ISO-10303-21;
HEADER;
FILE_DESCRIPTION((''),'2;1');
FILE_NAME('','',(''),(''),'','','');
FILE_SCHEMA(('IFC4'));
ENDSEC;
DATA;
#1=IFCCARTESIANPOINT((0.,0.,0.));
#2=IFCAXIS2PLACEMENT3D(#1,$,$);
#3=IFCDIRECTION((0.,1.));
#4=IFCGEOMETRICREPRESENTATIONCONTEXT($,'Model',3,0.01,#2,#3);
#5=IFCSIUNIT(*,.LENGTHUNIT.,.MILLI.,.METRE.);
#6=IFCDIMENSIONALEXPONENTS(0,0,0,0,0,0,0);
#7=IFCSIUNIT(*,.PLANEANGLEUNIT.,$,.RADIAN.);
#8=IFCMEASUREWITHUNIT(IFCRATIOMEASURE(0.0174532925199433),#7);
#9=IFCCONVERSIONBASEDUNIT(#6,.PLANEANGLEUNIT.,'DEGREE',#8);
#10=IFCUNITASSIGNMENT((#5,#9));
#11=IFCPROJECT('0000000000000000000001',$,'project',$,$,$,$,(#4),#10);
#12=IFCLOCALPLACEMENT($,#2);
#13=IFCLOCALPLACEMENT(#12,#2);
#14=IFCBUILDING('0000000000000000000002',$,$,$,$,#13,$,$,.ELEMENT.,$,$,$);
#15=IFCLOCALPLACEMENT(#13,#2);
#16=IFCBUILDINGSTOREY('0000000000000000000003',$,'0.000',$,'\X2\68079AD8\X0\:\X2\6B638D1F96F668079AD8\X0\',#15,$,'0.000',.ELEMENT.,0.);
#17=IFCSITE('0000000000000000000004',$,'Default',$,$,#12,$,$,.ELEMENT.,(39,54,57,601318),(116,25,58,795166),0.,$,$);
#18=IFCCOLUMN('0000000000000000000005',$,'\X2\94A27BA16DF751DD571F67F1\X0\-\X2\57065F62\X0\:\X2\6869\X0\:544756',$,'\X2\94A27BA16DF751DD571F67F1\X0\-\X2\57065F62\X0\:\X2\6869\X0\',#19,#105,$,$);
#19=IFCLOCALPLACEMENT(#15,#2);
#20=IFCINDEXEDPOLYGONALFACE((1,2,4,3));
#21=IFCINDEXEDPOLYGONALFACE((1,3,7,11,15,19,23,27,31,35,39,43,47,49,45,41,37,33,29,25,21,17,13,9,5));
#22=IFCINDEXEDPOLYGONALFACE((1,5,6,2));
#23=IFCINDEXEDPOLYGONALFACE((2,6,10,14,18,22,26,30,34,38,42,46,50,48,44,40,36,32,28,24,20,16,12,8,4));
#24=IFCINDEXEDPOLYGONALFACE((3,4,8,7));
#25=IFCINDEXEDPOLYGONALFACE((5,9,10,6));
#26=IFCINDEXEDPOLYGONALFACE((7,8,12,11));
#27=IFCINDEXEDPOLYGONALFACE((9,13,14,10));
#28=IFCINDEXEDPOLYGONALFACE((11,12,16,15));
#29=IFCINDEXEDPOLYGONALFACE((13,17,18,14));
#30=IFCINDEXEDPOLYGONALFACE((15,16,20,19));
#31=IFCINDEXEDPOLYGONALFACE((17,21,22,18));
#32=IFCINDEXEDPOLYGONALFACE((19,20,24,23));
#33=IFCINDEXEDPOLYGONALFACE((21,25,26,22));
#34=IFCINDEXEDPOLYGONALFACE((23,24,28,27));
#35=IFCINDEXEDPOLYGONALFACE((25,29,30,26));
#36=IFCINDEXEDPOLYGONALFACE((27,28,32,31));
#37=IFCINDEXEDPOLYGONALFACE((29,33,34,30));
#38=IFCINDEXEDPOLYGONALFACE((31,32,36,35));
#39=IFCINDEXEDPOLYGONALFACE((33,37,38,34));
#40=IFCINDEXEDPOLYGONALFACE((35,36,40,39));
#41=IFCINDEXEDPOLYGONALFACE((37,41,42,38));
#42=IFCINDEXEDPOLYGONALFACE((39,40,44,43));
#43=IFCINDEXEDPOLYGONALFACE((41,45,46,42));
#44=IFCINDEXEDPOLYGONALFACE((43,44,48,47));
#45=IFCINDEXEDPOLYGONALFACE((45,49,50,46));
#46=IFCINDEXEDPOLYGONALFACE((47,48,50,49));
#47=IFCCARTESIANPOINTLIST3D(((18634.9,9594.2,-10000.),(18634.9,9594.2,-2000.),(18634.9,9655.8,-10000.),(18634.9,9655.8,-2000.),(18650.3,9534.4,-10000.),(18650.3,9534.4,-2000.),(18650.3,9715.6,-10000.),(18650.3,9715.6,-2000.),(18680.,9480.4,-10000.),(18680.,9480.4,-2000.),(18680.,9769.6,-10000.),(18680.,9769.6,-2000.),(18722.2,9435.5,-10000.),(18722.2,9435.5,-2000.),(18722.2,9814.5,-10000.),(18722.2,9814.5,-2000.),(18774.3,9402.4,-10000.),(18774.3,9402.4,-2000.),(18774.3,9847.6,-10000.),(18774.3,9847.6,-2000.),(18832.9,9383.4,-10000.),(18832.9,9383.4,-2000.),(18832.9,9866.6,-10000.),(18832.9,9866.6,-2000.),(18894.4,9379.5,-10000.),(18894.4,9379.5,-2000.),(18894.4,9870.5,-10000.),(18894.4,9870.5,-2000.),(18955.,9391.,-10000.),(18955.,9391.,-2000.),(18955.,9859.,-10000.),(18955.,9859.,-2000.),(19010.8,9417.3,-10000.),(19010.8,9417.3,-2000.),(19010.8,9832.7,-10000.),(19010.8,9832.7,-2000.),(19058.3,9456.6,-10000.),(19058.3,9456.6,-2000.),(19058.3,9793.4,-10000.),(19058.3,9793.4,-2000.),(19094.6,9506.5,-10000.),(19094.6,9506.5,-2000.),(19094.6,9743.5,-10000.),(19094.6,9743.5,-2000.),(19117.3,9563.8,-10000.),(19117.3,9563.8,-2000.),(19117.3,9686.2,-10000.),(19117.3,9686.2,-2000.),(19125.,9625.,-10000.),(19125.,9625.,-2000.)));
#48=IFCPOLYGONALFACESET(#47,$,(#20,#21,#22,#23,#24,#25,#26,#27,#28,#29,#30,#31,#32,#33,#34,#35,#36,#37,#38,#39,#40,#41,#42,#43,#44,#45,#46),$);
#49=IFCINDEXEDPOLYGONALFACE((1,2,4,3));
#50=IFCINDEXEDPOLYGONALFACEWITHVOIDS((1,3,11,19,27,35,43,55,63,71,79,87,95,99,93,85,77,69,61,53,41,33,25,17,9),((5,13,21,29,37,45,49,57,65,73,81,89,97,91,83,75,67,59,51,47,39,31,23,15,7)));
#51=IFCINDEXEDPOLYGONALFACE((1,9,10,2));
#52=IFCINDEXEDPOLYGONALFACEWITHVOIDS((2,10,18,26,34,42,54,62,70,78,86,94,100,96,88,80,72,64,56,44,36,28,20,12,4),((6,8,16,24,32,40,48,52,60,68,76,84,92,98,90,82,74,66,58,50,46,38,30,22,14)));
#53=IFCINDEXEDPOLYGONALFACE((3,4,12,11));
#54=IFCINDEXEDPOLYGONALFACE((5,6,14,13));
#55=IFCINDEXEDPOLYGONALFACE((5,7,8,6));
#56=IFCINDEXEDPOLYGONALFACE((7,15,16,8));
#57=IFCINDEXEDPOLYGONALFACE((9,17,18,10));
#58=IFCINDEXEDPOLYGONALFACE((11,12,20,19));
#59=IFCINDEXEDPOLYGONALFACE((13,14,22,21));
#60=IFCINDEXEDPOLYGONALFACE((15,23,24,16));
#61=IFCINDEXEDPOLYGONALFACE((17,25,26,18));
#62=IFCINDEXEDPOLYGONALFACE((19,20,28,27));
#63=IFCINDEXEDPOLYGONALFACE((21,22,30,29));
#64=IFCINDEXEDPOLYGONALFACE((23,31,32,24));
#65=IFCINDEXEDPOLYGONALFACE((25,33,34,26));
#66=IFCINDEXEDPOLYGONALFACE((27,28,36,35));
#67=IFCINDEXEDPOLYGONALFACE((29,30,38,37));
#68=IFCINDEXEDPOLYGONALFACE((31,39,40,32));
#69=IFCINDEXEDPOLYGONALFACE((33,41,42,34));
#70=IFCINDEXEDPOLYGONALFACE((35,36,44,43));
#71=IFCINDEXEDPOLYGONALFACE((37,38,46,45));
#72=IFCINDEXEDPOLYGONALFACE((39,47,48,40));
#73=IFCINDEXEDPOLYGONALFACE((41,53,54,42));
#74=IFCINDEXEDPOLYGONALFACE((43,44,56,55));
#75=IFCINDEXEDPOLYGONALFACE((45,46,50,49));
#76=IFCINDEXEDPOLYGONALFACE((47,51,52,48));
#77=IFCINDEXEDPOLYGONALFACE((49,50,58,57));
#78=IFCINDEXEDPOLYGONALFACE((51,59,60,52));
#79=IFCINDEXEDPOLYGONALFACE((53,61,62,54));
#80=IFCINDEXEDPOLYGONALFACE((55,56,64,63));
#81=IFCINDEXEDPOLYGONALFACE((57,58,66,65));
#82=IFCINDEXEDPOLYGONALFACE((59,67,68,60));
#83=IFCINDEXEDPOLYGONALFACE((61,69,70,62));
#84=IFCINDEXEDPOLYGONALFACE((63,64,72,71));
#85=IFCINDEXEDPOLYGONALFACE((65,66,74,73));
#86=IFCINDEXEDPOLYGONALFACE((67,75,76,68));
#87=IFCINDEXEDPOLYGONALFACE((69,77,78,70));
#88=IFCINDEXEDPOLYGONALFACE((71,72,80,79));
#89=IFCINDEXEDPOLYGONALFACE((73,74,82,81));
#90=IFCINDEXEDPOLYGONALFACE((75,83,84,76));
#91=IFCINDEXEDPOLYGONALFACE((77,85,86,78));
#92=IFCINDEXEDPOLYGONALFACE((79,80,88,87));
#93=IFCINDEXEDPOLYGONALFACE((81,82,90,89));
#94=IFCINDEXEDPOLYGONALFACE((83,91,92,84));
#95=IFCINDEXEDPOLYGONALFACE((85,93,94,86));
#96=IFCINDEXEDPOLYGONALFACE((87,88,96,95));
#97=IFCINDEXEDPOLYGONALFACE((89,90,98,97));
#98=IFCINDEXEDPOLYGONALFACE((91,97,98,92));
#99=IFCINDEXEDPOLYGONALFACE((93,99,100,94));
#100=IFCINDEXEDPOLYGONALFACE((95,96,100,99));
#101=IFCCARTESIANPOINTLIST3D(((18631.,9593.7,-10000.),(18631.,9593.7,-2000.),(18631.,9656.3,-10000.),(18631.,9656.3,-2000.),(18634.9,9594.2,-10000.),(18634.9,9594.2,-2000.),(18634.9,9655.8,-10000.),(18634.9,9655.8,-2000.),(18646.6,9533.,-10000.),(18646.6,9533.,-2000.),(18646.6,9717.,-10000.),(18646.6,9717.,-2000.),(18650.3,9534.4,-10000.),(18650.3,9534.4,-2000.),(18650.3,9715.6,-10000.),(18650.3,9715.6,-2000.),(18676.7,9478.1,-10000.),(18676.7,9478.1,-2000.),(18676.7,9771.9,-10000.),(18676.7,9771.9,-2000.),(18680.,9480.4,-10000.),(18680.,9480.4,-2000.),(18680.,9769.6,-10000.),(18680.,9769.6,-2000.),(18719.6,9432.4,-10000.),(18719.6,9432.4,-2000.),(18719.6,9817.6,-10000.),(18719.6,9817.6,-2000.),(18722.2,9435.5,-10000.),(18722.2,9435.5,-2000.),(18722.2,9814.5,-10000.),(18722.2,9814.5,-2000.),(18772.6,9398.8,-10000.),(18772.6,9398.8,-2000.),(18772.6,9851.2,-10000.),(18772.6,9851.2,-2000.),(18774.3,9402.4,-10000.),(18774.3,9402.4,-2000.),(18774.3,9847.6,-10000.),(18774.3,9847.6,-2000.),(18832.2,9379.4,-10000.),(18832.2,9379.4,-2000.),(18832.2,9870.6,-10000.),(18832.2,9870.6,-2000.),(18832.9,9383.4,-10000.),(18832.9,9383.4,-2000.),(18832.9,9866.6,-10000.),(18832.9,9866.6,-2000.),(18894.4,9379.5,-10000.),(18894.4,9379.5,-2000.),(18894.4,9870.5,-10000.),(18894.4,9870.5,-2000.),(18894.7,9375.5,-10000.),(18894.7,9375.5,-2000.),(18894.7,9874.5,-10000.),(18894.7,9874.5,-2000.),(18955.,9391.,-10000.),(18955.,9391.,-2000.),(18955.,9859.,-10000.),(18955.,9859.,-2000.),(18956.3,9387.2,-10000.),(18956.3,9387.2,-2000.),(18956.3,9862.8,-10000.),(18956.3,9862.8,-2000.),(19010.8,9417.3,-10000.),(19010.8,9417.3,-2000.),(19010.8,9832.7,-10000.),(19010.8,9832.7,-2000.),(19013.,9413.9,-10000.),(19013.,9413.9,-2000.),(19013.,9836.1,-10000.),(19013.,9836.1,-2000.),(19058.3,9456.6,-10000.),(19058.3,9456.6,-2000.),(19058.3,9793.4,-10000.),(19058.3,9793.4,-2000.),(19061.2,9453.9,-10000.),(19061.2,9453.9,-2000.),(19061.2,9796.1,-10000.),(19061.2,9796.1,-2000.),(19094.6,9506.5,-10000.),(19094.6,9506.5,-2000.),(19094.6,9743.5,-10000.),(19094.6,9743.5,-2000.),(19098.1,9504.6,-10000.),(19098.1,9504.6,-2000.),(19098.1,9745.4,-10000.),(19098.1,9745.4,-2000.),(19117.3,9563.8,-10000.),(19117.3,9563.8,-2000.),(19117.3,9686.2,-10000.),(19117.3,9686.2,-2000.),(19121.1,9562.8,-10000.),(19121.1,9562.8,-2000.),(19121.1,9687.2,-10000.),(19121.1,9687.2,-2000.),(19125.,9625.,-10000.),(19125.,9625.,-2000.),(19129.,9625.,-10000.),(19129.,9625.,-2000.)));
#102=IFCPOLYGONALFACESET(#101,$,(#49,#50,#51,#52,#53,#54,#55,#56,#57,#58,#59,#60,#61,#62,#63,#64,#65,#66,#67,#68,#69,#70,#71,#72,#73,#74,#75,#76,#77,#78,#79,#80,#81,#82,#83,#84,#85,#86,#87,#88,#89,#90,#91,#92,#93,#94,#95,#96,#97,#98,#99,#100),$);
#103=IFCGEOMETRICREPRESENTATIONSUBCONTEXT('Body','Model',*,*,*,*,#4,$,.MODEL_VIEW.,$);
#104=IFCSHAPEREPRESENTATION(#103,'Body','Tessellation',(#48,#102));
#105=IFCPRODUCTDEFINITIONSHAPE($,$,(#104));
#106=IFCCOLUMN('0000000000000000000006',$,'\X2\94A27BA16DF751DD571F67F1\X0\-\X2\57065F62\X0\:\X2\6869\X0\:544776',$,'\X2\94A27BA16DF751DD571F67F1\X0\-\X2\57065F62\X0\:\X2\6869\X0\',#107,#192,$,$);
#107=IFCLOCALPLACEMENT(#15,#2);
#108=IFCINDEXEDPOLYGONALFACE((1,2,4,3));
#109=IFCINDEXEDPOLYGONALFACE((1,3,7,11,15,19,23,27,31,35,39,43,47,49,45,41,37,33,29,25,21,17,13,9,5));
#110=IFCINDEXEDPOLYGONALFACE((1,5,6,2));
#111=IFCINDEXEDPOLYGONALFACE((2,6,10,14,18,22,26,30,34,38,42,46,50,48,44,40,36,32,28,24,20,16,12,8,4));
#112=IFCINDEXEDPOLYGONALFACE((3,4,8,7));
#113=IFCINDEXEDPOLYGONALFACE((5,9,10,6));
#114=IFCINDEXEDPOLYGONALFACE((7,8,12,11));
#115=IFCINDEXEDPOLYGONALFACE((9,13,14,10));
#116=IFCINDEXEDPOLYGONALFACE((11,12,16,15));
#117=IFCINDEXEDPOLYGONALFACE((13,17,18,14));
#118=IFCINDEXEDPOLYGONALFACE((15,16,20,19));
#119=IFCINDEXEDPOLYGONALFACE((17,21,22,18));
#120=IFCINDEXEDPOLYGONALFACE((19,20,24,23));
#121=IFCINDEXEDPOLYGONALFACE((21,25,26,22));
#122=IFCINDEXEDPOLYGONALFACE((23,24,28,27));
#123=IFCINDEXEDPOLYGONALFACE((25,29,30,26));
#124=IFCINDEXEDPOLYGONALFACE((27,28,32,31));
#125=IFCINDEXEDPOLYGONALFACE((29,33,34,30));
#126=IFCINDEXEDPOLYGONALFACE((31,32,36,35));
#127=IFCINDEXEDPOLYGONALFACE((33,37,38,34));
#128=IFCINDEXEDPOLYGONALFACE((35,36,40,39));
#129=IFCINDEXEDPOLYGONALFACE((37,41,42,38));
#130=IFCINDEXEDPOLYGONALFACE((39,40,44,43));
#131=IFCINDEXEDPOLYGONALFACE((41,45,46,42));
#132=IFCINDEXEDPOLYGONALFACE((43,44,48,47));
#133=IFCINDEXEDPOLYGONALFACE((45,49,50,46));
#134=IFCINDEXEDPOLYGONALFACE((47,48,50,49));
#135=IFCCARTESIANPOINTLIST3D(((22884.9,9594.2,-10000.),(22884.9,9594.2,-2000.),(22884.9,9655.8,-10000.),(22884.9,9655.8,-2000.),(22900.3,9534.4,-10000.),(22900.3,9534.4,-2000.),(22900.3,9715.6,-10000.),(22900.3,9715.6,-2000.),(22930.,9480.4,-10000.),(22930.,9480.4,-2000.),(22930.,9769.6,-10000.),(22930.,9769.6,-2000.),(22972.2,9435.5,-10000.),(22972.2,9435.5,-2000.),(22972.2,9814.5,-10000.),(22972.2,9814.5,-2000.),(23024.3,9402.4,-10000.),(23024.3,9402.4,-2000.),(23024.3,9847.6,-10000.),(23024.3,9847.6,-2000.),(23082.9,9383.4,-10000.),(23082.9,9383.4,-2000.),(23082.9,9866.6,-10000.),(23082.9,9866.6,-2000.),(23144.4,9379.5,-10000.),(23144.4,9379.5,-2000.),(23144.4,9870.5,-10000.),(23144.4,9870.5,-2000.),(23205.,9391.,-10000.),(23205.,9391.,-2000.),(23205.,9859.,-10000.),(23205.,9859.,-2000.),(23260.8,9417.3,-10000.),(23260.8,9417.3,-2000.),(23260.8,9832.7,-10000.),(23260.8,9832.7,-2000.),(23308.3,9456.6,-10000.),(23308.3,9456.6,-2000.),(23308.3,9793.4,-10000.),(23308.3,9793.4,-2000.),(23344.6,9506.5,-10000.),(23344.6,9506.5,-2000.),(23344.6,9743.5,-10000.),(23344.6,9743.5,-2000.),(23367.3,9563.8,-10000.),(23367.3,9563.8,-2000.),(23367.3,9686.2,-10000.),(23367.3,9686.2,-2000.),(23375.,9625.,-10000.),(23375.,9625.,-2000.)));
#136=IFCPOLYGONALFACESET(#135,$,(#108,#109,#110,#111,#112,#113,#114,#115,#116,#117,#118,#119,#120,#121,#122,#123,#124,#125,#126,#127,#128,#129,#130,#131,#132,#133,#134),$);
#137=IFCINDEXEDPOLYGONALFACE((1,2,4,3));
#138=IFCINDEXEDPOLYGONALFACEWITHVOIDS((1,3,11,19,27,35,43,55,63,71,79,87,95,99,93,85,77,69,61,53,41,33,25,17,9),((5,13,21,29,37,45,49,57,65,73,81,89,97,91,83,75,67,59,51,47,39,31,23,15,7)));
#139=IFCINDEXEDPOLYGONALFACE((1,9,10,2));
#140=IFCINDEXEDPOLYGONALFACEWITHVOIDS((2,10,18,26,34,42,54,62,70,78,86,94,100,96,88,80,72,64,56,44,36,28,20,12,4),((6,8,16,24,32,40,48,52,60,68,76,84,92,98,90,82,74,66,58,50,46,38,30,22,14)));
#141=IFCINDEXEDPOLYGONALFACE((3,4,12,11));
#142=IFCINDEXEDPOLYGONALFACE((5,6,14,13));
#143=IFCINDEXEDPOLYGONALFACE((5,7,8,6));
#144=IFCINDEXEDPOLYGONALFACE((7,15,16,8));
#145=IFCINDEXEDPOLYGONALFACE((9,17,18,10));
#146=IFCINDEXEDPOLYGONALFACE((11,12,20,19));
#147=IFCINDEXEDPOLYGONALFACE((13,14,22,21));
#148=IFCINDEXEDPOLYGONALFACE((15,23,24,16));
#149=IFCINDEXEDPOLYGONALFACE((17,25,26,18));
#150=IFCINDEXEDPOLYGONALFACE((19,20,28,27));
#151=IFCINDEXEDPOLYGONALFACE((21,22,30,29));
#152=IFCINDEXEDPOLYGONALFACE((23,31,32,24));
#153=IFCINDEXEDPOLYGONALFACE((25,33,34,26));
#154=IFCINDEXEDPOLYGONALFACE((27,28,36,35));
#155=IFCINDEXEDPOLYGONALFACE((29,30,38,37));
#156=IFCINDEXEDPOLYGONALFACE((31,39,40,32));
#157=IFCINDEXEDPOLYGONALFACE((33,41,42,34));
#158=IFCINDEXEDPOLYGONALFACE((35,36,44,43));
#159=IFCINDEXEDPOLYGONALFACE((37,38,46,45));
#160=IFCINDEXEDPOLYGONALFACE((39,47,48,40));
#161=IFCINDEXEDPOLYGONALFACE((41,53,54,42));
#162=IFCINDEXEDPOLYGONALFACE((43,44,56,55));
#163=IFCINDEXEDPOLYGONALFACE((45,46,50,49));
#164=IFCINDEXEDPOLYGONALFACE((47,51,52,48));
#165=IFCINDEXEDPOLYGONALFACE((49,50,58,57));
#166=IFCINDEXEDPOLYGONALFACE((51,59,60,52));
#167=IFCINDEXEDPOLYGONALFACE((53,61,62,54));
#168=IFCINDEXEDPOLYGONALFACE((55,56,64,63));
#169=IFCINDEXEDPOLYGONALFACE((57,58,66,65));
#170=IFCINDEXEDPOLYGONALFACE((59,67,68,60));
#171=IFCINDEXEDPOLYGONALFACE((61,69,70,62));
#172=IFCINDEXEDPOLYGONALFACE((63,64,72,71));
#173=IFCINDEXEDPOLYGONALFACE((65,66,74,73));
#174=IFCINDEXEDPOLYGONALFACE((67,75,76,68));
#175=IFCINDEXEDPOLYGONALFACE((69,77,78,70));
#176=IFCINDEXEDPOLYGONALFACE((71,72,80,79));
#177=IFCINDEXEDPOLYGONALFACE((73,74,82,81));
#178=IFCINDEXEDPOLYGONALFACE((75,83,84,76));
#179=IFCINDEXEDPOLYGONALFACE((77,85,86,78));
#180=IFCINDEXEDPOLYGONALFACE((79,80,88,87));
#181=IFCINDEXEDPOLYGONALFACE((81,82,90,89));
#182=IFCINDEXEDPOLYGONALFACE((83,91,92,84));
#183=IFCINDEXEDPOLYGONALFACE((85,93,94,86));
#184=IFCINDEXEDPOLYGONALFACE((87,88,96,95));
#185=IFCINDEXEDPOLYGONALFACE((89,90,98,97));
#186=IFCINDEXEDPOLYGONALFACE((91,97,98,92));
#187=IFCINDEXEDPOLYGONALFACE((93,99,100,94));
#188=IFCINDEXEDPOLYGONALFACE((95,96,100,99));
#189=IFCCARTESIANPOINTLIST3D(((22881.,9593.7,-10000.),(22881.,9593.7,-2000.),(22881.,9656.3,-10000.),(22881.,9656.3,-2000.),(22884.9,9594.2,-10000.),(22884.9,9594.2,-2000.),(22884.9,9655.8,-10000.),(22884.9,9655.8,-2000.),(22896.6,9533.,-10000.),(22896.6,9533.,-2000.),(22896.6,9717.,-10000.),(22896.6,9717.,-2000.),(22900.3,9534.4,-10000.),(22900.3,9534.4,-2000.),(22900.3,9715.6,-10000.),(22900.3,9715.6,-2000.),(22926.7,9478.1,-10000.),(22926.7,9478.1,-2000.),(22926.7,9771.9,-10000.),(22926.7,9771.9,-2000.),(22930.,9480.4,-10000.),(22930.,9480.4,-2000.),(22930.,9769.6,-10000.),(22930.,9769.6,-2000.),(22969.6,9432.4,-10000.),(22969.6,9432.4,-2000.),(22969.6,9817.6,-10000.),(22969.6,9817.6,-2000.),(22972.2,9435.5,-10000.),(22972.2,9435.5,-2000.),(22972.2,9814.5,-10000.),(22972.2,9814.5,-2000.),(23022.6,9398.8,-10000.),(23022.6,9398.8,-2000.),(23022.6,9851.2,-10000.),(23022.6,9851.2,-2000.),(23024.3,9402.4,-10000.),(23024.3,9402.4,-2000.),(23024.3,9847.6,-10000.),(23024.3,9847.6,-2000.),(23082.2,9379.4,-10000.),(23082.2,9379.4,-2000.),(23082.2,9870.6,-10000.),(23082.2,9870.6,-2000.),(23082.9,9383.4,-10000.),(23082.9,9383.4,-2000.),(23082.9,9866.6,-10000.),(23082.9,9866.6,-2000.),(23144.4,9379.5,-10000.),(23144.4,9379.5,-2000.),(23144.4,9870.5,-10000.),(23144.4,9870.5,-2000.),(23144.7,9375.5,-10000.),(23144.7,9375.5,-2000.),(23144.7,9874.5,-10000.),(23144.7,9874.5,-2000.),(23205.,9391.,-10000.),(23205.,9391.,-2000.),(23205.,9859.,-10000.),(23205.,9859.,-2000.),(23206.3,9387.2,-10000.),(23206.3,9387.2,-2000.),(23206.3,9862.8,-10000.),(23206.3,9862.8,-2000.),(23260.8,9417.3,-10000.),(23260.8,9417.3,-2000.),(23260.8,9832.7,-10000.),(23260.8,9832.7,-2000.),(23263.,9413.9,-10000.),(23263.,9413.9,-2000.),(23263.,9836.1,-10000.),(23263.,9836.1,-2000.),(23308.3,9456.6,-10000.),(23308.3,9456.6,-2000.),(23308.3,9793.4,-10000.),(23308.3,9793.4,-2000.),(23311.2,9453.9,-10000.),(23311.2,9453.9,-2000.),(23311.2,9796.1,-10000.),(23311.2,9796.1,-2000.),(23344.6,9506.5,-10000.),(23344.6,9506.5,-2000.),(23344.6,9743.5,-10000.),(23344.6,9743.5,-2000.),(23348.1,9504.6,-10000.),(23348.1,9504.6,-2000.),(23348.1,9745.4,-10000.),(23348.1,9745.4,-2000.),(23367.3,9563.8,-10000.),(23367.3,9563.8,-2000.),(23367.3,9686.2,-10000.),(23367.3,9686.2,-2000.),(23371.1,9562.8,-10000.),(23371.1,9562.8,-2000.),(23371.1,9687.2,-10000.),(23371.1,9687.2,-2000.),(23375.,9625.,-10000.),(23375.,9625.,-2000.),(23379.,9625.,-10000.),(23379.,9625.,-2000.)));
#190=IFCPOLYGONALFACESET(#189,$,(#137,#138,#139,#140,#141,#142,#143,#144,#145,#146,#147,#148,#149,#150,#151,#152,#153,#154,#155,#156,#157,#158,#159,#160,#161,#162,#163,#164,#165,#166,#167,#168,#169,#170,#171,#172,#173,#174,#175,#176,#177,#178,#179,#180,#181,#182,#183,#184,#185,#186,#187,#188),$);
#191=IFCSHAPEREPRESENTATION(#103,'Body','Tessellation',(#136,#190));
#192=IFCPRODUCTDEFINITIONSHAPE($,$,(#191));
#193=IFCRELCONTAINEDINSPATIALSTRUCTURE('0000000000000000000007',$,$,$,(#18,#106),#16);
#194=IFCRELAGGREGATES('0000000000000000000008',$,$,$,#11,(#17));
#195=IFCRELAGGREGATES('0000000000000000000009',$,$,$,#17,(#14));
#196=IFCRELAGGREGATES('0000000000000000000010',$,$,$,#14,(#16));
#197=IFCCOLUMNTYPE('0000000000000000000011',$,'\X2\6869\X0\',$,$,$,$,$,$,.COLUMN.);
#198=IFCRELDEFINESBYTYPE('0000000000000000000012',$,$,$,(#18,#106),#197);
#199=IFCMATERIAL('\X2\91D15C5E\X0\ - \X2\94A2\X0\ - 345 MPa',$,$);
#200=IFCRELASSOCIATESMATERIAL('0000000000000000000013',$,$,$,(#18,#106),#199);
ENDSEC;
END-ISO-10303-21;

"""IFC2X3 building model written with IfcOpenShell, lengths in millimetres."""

from ifc_helpers import new_model, entity, si_unit, converted_unit, direction, frame, frame_2d, origin, place, context, subcontext, project, spatial, circle, hollow_circle, extrude, source, transform, mapped, material, type_object, type_shapes, element, save


model = new_model("IFC2X3")

# Units and contexts
model_context = context("Model", 3, precision=0.01, world=origin(), true_north=direction((0.0, 1.0)))
body_context = subcontext(model_context, "Body", "Model", "MODEL_VIEW")
ifc_project = project(units=[si_unit("LENGTHUNIT", "METRE", prefix="MILLI"), converted_unit("PLANEANGLEUNIT", "DEGREE", entity("IfcRatioMeasure", 0.0174532925199433), si_unit("PLANEANGLEUNIT", "RADIAN"), dimensions=[0, 0, 0, 0, 0, 0, 0])], contexts=[model_context])

# Site, building, storey
site_placement = place(None, origin())
site = spatial("IfcSite", under=ifc_project, at=site_placement, Name="Default", CompositionType="ELEMENT", RefLatitude=(39, 54, 57, 601318), RefLongitude=(116, 25, 58, 795166), RefElevation=0.0)
building_placement = place(site_placement, origin())
building = spatial("IfcBuilding", under=site, at=building_placement, CompositionType="ELEMENT")
storey_placement = place(building_placement, origin())
storey = spatial("IfcBuildingStorey", under=building, at=storey_placement, Name="0.000", ObjectType="标高:正负零标高", LongName="0.000", CompositionType="ELEMENT", Elevation=0.0)

# Columns
ifc_material_1 = material(Name="金属 - 钢 - 345 MPa")
column_type_1 = type_object("IfcColumnType", Name="桩", PredefinedType="COLUMN")
shared_shape_1 = source(origin(), body_context, "Body", "SweptSolid", [
    extrude(circle(Radius=246.0, at=frame_2d((0.0, 0.0), x_axis=(1.0, 0.0))), frame((0.0, 0.0, -10000.0)), (0.0, 0.0, 1.0), 8000.0),
    extrude(hollow_circle(Radius=250.0, WallThickness=4.0, at=frame_2d((0.0, 0.0), x_axis=(1.0, 0.0))), frame((0.0, 0.0, -10000.0)), (0.0, 0.0, 1.0), 8000.0),
])
type_shapes(column_type_1, [shared_shape_1])
for number, where, name in (
    (1, (18879.0, 9625.0, 0.0), "钢管混凝土柱-圆形:桩:544756"),
    (2, (23129.0, 9625.0, 0.0), "钢管混凝土柱-圆形:桩:544776"),
):
    element("IfcColumn", number, at=place(storey_placement, frame(where)), inside=storey, type_object=column_type_1, material=ifc_material_1, Name=name, ObjectType="钢管混凝土柱-圆形:桩", context=body_context, shape_type="MappedRepresentation", body=[
        mapped(shared_shape_1, transform((0.0, 0.0, 0.0), scale=1.0)),
    ])

save(model, "model.ifc")
